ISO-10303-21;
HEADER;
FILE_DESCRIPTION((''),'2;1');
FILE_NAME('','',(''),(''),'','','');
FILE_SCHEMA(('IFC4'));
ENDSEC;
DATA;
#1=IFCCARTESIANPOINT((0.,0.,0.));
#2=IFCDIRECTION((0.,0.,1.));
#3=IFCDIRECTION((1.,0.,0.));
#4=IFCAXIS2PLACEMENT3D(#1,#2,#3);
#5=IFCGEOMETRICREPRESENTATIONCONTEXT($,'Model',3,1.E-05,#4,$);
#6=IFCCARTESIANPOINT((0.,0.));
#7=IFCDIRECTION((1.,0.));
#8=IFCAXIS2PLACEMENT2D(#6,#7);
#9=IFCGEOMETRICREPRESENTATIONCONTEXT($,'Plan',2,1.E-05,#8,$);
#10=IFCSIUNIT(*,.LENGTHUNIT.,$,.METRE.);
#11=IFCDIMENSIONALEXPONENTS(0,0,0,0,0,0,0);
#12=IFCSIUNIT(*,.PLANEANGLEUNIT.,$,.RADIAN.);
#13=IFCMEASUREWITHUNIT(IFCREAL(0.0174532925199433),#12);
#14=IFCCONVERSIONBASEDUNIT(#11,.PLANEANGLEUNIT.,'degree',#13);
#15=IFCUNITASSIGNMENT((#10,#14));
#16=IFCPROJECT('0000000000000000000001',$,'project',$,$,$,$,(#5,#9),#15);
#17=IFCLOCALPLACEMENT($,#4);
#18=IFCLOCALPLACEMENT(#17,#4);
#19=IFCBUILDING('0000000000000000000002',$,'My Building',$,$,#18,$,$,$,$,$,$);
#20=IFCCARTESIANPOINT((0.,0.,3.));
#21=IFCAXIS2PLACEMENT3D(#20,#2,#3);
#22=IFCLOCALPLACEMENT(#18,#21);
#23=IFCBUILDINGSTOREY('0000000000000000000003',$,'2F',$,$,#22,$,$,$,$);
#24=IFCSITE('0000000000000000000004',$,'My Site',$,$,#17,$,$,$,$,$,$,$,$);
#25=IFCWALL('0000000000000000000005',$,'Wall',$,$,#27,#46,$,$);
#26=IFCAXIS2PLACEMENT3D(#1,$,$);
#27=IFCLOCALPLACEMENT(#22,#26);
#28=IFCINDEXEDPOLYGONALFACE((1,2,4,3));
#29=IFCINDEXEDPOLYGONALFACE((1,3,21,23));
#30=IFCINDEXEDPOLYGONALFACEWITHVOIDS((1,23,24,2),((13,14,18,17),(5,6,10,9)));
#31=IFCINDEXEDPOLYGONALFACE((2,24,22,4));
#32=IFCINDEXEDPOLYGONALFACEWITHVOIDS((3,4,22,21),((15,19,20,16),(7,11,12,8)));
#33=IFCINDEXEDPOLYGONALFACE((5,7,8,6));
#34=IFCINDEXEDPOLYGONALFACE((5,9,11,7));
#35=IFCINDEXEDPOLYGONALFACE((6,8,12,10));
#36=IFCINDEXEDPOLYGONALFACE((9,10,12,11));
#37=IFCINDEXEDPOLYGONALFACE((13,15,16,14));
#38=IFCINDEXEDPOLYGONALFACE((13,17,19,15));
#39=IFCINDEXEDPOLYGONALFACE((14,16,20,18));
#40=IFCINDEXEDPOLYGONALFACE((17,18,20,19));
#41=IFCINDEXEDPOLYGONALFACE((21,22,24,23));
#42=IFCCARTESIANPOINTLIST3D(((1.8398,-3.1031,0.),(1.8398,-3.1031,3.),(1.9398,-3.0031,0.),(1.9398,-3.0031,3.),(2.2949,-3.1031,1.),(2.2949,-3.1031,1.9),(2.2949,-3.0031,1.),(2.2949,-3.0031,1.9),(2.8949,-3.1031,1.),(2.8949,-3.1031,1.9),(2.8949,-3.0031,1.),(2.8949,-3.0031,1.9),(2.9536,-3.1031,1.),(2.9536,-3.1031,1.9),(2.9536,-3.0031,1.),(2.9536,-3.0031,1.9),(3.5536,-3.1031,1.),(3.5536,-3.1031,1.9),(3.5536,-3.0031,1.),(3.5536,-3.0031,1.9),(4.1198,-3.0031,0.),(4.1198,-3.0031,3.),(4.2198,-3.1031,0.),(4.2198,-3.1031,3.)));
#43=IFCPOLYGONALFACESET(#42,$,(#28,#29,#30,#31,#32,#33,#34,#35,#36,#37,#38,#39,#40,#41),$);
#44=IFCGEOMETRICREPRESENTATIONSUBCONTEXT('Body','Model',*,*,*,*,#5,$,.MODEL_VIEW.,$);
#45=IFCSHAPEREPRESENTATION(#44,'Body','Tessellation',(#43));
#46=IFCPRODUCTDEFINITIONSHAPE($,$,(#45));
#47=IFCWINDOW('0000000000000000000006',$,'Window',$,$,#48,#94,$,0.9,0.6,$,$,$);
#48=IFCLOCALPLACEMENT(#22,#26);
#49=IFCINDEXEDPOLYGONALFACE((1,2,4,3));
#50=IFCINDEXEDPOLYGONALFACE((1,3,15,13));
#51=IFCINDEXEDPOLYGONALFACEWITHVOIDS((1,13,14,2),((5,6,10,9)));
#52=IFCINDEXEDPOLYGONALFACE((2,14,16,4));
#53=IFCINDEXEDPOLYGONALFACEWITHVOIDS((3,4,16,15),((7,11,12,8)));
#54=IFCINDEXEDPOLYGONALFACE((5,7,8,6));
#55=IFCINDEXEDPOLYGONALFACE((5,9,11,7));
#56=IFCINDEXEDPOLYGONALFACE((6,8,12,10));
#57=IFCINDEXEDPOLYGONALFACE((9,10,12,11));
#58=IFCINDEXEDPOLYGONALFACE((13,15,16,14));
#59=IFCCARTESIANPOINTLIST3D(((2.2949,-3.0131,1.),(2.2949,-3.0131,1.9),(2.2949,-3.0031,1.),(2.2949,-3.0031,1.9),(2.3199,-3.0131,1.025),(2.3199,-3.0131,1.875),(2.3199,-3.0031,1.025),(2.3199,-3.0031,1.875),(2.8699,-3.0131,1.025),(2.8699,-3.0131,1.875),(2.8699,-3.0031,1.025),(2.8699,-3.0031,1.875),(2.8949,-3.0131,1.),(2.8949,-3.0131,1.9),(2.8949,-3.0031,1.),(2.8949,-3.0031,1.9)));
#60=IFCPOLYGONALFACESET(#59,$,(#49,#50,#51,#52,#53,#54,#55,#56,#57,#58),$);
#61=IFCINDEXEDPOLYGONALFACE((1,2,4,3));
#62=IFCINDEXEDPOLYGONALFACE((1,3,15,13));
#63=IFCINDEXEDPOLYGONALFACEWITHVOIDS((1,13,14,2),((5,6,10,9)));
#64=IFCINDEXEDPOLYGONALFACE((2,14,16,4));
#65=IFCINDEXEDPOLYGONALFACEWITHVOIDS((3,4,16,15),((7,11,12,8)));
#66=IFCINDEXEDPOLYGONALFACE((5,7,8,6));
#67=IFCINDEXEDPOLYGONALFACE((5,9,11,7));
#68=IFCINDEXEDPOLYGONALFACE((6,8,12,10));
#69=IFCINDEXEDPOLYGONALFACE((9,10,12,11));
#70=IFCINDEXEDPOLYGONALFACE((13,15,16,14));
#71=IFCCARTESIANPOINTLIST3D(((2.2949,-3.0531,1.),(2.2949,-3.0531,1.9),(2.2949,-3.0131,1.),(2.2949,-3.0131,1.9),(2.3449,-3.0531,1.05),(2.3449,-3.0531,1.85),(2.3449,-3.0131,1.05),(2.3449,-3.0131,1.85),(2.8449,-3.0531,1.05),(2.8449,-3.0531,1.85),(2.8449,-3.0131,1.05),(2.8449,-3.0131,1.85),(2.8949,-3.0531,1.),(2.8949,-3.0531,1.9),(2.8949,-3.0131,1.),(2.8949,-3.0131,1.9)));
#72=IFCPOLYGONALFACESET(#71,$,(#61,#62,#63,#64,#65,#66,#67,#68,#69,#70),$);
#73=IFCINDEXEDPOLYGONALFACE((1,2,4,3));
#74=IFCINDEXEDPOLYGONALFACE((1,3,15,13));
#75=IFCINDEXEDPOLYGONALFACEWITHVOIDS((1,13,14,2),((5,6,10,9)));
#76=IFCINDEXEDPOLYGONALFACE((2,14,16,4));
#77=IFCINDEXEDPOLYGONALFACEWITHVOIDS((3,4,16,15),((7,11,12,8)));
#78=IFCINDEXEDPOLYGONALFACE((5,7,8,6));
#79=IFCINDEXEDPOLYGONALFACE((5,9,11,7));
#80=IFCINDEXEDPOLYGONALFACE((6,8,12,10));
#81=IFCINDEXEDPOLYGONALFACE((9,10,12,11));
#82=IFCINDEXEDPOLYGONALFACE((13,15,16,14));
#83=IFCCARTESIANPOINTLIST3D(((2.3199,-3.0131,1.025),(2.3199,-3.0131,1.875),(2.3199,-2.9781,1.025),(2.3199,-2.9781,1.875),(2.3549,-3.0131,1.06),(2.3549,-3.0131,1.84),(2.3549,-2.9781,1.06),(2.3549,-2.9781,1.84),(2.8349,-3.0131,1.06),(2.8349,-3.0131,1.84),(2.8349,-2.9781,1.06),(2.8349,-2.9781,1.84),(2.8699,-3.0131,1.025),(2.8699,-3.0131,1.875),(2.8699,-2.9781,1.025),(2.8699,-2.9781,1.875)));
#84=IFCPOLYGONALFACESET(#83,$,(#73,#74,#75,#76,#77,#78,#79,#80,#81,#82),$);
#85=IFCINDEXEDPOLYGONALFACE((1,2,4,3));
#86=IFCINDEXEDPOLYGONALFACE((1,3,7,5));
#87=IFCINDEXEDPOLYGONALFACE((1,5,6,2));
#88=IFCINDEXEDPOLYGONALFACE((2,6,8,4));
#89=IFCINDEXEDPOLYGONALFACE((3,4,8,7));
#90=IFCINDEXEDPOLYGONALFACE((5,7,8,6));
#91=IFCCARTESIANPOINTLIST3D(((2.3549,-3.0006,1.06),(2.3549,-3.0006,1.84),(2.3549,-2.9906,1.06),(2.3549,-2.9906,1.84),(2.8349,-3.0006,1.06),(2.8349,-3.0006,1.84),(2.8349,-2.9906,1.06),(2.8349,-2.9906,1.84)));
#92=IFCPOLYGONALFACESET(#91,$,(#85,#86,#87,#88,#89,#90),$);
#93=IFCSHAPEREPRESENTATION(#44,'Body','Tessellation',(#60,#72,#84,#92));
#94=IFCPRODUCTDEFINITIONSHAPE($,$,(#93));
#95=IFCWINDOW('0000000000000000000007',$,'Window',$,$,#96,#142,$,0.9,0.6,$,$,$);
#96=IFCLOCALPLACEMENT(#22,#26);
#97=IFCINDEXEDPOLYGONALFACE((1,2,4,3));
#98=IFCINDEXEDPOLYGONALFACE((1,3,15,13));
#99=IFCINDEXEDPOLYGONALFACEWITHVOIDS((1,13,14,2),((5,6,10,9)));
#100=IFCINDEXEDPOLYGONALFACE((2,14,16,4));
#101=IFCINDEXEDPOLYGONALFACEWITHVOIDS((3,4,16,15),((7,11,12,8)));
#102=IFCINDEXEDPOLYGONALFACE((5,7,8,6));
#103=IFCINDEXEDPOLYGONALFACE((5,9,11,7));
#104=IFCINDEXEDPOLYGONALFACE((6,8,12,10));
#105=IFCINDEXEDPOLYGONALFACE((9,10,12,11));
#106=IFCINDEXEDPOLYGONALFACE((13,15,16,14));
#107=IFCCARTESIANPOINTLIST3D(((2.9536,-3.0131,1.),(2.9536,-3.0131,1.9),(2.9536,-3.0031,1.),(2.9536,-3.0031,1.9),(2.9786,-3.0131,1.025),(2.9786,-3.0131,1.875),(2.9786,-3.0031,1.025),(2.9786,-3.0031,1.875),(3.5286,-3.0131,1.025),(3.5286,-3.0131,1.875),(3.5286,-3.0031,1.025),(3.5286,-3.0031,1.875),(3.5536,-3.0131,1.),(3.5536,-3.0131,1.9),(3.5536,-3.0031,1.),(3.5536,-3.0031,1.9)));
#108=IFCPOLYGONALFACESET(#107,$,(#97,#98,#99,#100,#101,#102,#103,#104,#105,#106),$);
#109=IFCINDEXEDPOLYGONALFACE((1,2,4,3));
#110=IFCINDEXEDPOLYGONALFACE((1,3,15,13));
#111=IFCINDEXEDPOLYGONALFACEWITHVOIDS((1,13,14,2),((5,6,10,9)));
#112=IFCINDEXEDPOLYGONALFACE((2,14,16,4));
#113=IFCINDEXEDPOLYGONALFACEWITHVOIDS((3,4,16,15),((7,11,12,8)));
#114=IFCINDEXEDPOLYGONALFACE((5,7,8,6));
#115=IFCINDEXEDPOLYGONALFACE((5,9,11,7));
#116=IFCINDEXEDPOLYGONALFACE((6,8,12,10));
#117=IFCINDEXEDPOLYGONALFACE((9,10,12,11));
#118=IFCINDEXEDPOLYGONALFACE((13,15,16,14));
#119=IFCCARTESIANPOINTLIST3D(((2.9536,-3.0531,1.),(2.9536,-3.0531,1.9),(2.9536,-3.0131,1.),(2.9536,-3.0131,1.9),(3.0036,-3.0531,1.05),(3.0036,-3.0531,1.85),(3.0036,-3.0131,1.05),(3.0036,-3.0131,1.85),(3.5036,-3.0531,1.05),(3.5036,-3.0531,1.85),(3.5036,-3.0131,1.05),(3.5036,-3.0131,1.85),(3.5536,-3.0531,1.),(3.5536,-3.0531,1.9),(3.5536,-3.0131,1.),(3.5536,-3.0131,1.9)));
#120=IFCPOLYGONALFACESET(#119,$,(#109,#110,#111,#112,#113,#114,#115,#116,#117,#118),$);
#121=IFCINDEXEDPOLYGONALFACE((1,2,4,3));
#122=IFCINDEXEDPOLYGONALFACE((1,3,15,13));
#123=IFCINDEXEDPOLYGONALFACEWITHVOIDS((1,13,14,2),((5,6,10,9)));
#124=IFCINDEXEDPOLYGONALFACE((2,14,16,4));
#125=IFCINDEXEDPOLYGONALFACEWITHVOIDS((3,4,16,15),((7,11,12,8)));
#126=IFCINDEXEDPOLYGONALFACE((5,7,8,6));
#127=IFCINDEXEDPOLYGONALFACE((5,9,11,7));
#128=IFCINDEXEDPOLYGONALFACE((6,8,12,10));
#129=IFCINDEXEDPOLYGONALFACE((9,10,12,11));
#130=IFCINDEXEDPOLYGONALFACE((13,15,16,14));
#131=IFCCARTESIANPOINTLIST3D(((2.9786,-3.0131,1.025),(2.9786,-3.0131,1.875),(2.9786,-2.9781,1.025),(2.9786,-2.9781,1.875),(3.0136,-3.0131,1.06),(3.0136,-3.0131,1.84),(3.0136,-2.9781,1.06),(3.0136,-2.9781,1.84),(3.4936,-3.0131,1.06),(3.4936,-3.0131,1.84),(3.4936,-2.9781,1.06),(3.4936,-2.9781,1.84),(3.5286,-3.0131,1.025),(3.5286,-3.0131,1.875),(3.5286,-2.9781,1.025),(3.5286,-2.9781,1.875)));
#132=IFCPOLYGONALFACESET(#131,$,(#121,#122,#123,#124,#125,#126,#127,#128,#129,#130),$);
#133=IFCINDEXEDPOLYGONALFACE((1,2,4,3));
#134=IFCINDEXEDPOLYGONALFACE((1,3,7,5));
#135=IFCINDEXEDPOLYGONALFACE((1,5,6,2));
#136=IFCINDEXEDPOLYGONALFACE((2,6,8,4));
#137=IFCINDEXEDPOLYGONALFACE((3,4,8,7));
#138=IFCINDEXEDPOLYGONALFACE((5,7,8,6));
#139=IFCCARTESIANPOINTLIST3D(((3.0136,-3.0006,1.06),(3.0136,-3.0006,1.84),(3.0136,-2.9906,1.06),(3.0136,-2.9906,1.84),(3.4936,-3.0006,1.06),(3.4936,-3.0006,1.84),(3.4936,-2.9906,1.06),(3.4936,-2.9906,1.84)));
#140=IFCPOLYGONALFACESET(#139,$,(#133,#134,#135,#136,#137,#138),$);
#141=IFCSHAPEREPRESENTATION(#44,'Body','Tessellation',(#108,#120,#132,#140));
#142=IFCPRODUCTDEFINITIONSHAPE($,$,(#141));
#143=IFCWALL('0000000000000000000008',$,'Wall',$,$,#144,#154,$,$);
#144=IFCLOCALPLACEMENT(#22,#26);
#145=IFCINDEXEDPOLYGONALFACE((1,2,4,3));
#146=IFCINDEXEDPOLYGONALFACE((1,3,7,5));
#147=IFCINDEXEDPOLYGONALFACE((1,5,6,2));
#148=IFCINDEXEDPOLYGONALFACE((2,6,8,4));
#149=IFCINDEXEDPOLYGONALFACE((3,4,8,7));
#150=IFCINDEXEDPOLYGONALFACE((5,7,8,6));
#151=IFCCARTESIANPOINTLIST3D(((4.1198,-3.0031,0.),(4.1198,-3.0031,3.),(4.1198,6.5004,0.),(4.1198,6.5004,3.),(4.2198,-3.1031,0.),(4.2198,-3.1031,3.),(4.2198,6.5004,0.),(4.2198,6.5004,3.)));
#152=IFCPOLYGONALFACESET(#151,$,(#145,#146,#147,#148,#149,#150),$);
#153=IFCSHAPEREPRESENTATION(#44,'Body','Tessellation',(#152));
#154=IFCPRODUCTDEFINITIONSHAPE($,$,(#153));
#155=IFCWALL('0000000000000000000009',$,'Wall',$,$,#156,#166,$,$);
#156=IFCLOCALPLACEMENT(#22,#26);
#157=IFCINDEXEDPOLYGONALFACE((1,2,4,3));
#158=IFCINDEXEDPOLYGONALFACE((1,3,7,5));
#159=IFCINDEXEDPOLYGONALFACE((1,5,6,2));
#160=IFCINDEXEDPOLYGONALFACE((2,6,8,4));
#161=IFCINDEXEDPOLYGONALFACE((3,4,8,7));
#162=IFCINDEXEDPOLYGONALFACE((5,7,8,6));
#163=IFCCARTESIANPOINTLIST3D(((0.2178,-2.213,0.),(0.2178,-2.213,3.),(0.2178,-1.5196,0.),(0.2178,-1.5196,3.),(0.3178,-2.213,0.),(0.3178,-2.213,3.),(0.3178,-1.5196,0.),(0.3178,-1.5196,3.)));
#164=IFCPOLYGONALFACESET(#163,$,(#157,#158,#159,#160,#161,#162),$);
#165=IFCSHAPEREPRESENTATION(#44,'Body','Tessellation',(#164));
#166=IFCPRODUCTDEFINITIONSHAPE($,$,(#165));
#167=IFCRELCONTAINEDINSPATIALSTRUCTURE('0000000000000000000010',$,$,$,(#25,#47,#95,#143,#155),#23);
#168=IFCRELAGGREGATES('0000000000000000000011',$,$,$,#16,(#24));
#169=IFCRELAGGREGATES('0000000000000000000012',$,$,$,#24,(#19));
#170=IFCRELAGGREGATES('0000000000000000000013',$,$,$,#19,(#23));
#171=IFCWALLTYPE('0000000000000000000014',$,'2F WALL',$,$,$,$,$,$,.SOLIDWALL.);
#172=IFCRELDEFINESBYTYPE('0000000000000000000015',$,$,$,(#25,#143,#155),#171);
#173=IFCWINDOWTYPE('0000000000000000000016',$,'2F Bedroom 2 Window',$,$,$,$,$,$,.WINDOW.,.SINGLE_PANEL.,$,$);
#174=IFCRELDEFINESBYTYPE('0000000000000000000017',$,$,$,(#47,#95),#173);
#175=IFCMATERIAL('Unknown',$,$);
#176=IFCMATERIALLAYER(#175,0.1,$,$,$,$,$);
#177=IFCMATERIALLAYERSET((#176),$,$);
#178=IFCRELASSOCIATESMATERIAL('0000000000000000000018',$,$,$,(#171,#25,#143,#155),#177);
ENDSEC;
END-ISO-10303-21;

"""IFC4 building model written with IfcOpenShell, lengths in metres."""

from ifc_helpers import new_model, entity, si_unit, converted_unit, frame, origin_with_axes, origin_2d_with_axis, place, context, subcontext, project, spatial, line, indexed_curve, outline, extrude, shape, source, transform, mapped, material, layer, layer_set, layer_usage, type_object, type_shapes, element, fill, save


model = new_model("IFC4")

# Units and contexts
model_context = context("Model", 3, precision=1e-05, world=origin_with_axes())
plan_context = context("Plan", 2, precision=1e-05, world=origin_2d_with_axis())
body_context_1 = subcontext(model_context, "Body", "Model", "MODEL_VIEW")
body_context_2 = subcontext(plan_context, "Body", "Plan", "PLAN_VIEW")
ifc_project = project(units=[si_unit("LENGTHUNIT", "METRE"), converted_unit("PLANEANGLEUNIT", "degree", entity("IfcReal", 0.0174532925199433), si_unit("PLANEANGLEUNIT", "RADIAN"), dimensions=[0, 0, 0, 0, 0, 0, 0])], contexts=[model_context, plan_context])

# Site, building, storey
site_placement = place(None, origin_with_axes())
site = spatial("IfcSite", under=ifc_project, at=site_placement, Name="My Site")
building_placement = place(site_placement, origin_with_axes())
building = spatial("IfcBuilding", under=site, at=building_placement, Name="My Building")
storey_placement = place(building_placement, frame((0.0, 0.0, 3.0), z_axis=(0.0, 0.0, 1.0), x_axis=(1.0, 0.0, 0.0)))
storey = spatial("IfcBuildingStorey", under=building, at=storey_placement, Name="2F")

# Shared definitions
ifc_material = material(Name="Unknown")

# Shared definitions
ifc_layer_1 = layer(ifc_material, 0.1)
ifc_layer_set_1 = layer_set([ifc_layer_1])
wall_type = type_object("IfcWallType", Name="2F WALL", PredefinedType="SOLIDWALL", material=ifc_layer_set_1)

# Wall, openings, windows
ifc_layer_usage_1 = layer_usage(ifc_layer_set_1, "AXIS2", "POSITIVE", 0.0)
wall_1_placement = place(storey_placement, frame((1.8398, -3.1031, 0.0), z_axis=(0.0, 0.0, 1.0), x_axis=(1.0, 0.0, 0.0)))
wall_1 = element("IfcWall", 1, at=wall_1_placement, inside=storey, type_object=wall_type, material=ifc_layer_usage_1, Name="Wall", context=body_context_1, shape_type="SweptSolid", body=[
    extrude(outline(indexed_curve([(0.0, 0.0), (0.1, 0.1), (2.28, 0.1), (2.38, 0.0)], segments=[line(1, 2, 3, 4, 1)])), origin_with_axes(), (0.0, 0.0, 1.0), 3.0),
])
shared_shape_1 = source(origin_with_axes(), body_context_1, "Body", "SweptSolid", [
    extrude(outline(indexed_curve([(0.0, 0.0), (0.6, 0.0), (0.6, 0.9), (0.0, 0.9)], segments=[line(1, 2, 3, 4, 1)])), frame((0.0, -0.6, 0.0), z_axis=(0.0, -1.0, 0.0), x_axis=(1.0, 0.0, 0.0)), (0.0, 0.0, -1.0), 1.2),
])
opening_1_placement = place(wall_1_placement, frame((0.4551, 0.0, 1.0), z_axis=(0.0, 0.0, 1.0), x_axis=(1.0, 0.0, 0.0)))
opening_1 = element("IfcOpeningElement", 2, at=opening_1_placement, cuts=wall_1, PredefinedType="OPENING", context=body_context_1, shape_type="MappedRepresentation", body=[
    mapped(shared_shape_1, transform((0.0, 0.0, 0.0), x_axis=(1.0, 0.0, 0.0), y_axis=(0.0, 1.0, 0.0), z_axis=(0.0, 0.0, 1.0), scale=1.0)),
])
opening_2_placement = place(wall_1_placement, frame((1.1137, 0.0, 1.0), z_axis=(0.0, 0.0, 1.0), x_axis=(1.0, 0.0, 0.0)))
opening_2 = element("IfcOpeningElement", 3, at=opening_2_placement, cuts=wall_1, PredefinedType="OPENING", context=body_context_1, shape_type="MappedRepresentation", body=[
    mapped(shared_shape_1, transform((0.0, 0.0, 0.0), x_axis=(1.0, 0.0, 0.0), y_axis=(0.0, 1.0, 0.0), z_axis=(0.0, 0.0, 1.0), scale=1.0)),
])
window_type = type_object("IfcWindowType", Name="2F Bedroom 2 Window", PartitioningType="SINGLE_PANEL", PredefinedType="WINDOW")
shared_shape_2 = source(origin_with_axes(), body_context_1, "Body", "SweptSolid", [
    extrude(outline(indexed_curve([(0.0, 0.0), (0.6, 0.0), (0.6, 0.9), (0.0, 0.9)], segments=[line(1, 2, 3, 4, 1)]), holes=[indexed_curve([(0.025, 0.025), (0.575, 0.025), (0.575, 0.875), (0.025, 0.875)], segments=[line(1, 2, 3, 4, 1)])]), frame((0.0, 0.09, 0.0), z_axis=(0.0, -1.0, 0.0), x_axis=(1.0, 0.0, 0.0)), (0.0, 0.0, -1.0), 0.01),
    extrude(outline(indexed_curve([(0.0, 0.0), (0.6, 0.0), (0.6, 0.9), (0.0, 0.9)], segments=[line(1, 2, 3, 4, 1)]), holes=[indexed_curve([(0.05, 0.05), (0.55, 0.05), (0.55, 0.85), (0.05, 0.85)], segments=[line(1, 2, 3, 4, 1)])]), frame((0.0, 0.05, 0.0), z_axis=(0.0, -1.0, 0.0), x_axis=(1.0, 0.0, 0.0)), (0.0, 0.0, -1.0), 0.04),
    extrude(outline(indexed_curve([(0.0, 0.0), (0.55, 0.0), (0.55, 0.85), (0.0, 0.85)], segments=[line(1, 2, 3, 4, 1)]), holes=[indexed_curve([(0.035, 0.035), (0.515, 0.035), (0.515, 0.815), (0.035, 0.815)], segments=[line(1, 2, 3, 4, 1)])]), frame((0.025, 0.09, 0.025), z_axis=(0.0, -1.0, 0.0), x_axis=(1.0, 0.0, 0.0)), (0.0, 0.0, -1.0), 0.035),
    extrude(outline(indexed_curve([(0.035, 0.035), (0.515, 0.035), (0.515, 0.815), (0.035, 0.815)], segments=[line(1, 2, 3, 4, 1)])), frame((0.025, 0.1025, 0.025), z_axis=(0.0, -1.0, 0.0), x_axis=(1.0, 0.0, 0.0)), (0.0, 0.0, -1.0), 0.01),
])
shared_shape_3 = source(origin_with_axes(), body_context_2, "Body", "Curve2D", [
    entity("IfcIndexedPolyCurve", entity("IfcCartesianPointList2D", [[0.05, 0.05], [0.55, 0.05]])),
    entity("IfcIndexedPolyCurve", entity("IfcCartesianPointList2D", [[0.0, 0.1], [0.025, 0.1], [0.025, 0.09], [0.05, 0.09], [0.05, 0.05], [0.0, 0.05]]), [entity("IfcLineIndex", [1, 2, 3, 4, 5, 6, 1])]),
    entity("IfcIndexedPolyCurve", entity("IfcCartesianPointList2D", [[0.6, 0.1], [0.575, 0.1], [0.575, 0.09], [0.55, 0.09], [0.55, 0.05], [0.6, 0.05]]), [entity("IfcLineIndex", [1, 2, 3, 4, 5, 6, 1])]),
    entity("IfcIndexedPolyCurve", entity("IfcCartesianPointList2D", [[0.025, 0.09], [0.06, 0.09], [0.06, 0.125], [0.025, 0.125]]), [entity("IfcLineIndex", [1, 2, 3, 4, 1])]),
    entity("IfcIndexedPolyCurve", entity("IfcCartesianPointList2D", [[0.575, 0.09], [0.54, 0.09], [0.54, 0.125], [0.575, 0.125]]), [entity("IfcLineIndex", [1, 2, 3, 4, 1])]),
    entity("IfcIndexedPolyCurve", entity("IfcCartesianPointList2D", [[0.06, 0.09], [0.54, 0.09]])),
    entity("IfcIndexedPolyCurve", entity("IfcCartesianPointList2D", [[0.06, 0.125], [0.54, 0.125]])),
    entity("IfcIndexedPolyCurve", entity("IfcCartesianPointList2D", [[0.06, 0.1075], [0.54, 0.1075]])),
])
type_shapes(window_type, [shared_shape_2, shared_shape_3])
window_1_placement = place(opening_1_placement, origin_with_axes())
window_1 = element("IfcWindow", 4, at=window_1_placement, inside=storey, type_object=window_type, Name="Window", OverallHeight=0.9, OverallWidth=0.6, shapes=[
    shape(body_context_1, "Body", "MappedRepresentation", [mapped(shared_shape_2, transform((0.0, 0.0, 0.0), x_axis=(1.0, 0.0, 0.0), y_axis=(0.0, 1.0, 0.0), z_axis=(0.0, 0.0, 1.0), scale=1.0))]),
    shape(body_context_2, "Body", "MappedRepresentation", [mapped(shared_shape_3, transform((0.0, 0.0, 0.0), x_axis=(1.0, 0.0, 0.0), y_axis=(0.0, 1.0, 0.0), z_axis=(0.0, 0.0, 1.0), scale=1.0))]),
])
fill(opening_1, window_1)
window_2_placement = place(opening_2_placement, origin_with_axes())
window_2 = element("IfcWindow", 5, at=window_2_placement, inside=storey, type_object=window_type, Name="Window", OverallHeight=0.9, OverallWidth=0.6, shapes=[
    shape(body_context_1, "Body", "MappedRepresentation", [mapped(shared_shape_2, transform((0.0, 0.0, 0.0), x_axis=(1.0, 0.0, 0.0), y_axis=(0.0, 1.0, 0.0), z_axis=(0.0, 0.0, 1.0), scale=1.0))]),
    shape(body_context_2, "Body", "MappedRepresentation", [mapped(shared_shape_3, transform((0.0, 0.0, 0.0), x_axis=(1.0, 0.0, 0.0), y_axis=(0.0, 1.0, 0.0), z_axis=(0.0, 0.0, 1.0), scale=1.0))]),
])
fill(opening_2, window_2)

# Walls
ifc_layer_usage_2 = layer_usage(ifc_layer_set_1, "AXIS2", "POSITIVE", 0.0)
wall_2_placement = place(storey_placement, frame((4.2198, -3.1031, 0.0), z_axis=(0.0, 0.0, 1.0), x_axis=(0.0, 1.0, 0.0)))
element("IfcWall", 6, at=wall_2_placement, inside=storey, type_object=wall_type, material=ifc_layer_usage_2, Name="Wall", context=body_context_1, shape_type="SweptSolid", body=[
    extrude(outline(indexed_curve([(0.0, 0.0), (0.1, 0.1), (9.6034, 0.1), (9.6034, 0.0)], segments=[line(1, 2, 3, 4, 1)])), origin_with_axes(), (0.0, 0.0, 1.0), 3.0),
])
ifc_layer_usage_3 = layer_usage(ifc_layer_set_1, "AXIS2", "POSITIVE", 0.0)
wall_3_placement = place(storey_placement, frame((0.2178, -1.5196, 0.0), z_axis=(0.0, 0.0, 1.0), x_axis=(0.0, -1.0, 0.0)))
element("IfcWall", 7, at=wall_3_placement, inside=storey, type_object=wall_type, material=ifc_layer_usage_3, Name="Wall", context=body_context_1, shape_type="SweptSolid", body=[
    extrude(outline(indexed_curve([(0.0, 0.0), (0.0, 0.1), (0.6934, 0.1), (0.6934, 0.0)], segments=[line(1, 2, 3, 4, 1)])), origin_with_axes(), (0.0, 0.0, 1.0), 3.0),
])

save(model, "model.ifc")
